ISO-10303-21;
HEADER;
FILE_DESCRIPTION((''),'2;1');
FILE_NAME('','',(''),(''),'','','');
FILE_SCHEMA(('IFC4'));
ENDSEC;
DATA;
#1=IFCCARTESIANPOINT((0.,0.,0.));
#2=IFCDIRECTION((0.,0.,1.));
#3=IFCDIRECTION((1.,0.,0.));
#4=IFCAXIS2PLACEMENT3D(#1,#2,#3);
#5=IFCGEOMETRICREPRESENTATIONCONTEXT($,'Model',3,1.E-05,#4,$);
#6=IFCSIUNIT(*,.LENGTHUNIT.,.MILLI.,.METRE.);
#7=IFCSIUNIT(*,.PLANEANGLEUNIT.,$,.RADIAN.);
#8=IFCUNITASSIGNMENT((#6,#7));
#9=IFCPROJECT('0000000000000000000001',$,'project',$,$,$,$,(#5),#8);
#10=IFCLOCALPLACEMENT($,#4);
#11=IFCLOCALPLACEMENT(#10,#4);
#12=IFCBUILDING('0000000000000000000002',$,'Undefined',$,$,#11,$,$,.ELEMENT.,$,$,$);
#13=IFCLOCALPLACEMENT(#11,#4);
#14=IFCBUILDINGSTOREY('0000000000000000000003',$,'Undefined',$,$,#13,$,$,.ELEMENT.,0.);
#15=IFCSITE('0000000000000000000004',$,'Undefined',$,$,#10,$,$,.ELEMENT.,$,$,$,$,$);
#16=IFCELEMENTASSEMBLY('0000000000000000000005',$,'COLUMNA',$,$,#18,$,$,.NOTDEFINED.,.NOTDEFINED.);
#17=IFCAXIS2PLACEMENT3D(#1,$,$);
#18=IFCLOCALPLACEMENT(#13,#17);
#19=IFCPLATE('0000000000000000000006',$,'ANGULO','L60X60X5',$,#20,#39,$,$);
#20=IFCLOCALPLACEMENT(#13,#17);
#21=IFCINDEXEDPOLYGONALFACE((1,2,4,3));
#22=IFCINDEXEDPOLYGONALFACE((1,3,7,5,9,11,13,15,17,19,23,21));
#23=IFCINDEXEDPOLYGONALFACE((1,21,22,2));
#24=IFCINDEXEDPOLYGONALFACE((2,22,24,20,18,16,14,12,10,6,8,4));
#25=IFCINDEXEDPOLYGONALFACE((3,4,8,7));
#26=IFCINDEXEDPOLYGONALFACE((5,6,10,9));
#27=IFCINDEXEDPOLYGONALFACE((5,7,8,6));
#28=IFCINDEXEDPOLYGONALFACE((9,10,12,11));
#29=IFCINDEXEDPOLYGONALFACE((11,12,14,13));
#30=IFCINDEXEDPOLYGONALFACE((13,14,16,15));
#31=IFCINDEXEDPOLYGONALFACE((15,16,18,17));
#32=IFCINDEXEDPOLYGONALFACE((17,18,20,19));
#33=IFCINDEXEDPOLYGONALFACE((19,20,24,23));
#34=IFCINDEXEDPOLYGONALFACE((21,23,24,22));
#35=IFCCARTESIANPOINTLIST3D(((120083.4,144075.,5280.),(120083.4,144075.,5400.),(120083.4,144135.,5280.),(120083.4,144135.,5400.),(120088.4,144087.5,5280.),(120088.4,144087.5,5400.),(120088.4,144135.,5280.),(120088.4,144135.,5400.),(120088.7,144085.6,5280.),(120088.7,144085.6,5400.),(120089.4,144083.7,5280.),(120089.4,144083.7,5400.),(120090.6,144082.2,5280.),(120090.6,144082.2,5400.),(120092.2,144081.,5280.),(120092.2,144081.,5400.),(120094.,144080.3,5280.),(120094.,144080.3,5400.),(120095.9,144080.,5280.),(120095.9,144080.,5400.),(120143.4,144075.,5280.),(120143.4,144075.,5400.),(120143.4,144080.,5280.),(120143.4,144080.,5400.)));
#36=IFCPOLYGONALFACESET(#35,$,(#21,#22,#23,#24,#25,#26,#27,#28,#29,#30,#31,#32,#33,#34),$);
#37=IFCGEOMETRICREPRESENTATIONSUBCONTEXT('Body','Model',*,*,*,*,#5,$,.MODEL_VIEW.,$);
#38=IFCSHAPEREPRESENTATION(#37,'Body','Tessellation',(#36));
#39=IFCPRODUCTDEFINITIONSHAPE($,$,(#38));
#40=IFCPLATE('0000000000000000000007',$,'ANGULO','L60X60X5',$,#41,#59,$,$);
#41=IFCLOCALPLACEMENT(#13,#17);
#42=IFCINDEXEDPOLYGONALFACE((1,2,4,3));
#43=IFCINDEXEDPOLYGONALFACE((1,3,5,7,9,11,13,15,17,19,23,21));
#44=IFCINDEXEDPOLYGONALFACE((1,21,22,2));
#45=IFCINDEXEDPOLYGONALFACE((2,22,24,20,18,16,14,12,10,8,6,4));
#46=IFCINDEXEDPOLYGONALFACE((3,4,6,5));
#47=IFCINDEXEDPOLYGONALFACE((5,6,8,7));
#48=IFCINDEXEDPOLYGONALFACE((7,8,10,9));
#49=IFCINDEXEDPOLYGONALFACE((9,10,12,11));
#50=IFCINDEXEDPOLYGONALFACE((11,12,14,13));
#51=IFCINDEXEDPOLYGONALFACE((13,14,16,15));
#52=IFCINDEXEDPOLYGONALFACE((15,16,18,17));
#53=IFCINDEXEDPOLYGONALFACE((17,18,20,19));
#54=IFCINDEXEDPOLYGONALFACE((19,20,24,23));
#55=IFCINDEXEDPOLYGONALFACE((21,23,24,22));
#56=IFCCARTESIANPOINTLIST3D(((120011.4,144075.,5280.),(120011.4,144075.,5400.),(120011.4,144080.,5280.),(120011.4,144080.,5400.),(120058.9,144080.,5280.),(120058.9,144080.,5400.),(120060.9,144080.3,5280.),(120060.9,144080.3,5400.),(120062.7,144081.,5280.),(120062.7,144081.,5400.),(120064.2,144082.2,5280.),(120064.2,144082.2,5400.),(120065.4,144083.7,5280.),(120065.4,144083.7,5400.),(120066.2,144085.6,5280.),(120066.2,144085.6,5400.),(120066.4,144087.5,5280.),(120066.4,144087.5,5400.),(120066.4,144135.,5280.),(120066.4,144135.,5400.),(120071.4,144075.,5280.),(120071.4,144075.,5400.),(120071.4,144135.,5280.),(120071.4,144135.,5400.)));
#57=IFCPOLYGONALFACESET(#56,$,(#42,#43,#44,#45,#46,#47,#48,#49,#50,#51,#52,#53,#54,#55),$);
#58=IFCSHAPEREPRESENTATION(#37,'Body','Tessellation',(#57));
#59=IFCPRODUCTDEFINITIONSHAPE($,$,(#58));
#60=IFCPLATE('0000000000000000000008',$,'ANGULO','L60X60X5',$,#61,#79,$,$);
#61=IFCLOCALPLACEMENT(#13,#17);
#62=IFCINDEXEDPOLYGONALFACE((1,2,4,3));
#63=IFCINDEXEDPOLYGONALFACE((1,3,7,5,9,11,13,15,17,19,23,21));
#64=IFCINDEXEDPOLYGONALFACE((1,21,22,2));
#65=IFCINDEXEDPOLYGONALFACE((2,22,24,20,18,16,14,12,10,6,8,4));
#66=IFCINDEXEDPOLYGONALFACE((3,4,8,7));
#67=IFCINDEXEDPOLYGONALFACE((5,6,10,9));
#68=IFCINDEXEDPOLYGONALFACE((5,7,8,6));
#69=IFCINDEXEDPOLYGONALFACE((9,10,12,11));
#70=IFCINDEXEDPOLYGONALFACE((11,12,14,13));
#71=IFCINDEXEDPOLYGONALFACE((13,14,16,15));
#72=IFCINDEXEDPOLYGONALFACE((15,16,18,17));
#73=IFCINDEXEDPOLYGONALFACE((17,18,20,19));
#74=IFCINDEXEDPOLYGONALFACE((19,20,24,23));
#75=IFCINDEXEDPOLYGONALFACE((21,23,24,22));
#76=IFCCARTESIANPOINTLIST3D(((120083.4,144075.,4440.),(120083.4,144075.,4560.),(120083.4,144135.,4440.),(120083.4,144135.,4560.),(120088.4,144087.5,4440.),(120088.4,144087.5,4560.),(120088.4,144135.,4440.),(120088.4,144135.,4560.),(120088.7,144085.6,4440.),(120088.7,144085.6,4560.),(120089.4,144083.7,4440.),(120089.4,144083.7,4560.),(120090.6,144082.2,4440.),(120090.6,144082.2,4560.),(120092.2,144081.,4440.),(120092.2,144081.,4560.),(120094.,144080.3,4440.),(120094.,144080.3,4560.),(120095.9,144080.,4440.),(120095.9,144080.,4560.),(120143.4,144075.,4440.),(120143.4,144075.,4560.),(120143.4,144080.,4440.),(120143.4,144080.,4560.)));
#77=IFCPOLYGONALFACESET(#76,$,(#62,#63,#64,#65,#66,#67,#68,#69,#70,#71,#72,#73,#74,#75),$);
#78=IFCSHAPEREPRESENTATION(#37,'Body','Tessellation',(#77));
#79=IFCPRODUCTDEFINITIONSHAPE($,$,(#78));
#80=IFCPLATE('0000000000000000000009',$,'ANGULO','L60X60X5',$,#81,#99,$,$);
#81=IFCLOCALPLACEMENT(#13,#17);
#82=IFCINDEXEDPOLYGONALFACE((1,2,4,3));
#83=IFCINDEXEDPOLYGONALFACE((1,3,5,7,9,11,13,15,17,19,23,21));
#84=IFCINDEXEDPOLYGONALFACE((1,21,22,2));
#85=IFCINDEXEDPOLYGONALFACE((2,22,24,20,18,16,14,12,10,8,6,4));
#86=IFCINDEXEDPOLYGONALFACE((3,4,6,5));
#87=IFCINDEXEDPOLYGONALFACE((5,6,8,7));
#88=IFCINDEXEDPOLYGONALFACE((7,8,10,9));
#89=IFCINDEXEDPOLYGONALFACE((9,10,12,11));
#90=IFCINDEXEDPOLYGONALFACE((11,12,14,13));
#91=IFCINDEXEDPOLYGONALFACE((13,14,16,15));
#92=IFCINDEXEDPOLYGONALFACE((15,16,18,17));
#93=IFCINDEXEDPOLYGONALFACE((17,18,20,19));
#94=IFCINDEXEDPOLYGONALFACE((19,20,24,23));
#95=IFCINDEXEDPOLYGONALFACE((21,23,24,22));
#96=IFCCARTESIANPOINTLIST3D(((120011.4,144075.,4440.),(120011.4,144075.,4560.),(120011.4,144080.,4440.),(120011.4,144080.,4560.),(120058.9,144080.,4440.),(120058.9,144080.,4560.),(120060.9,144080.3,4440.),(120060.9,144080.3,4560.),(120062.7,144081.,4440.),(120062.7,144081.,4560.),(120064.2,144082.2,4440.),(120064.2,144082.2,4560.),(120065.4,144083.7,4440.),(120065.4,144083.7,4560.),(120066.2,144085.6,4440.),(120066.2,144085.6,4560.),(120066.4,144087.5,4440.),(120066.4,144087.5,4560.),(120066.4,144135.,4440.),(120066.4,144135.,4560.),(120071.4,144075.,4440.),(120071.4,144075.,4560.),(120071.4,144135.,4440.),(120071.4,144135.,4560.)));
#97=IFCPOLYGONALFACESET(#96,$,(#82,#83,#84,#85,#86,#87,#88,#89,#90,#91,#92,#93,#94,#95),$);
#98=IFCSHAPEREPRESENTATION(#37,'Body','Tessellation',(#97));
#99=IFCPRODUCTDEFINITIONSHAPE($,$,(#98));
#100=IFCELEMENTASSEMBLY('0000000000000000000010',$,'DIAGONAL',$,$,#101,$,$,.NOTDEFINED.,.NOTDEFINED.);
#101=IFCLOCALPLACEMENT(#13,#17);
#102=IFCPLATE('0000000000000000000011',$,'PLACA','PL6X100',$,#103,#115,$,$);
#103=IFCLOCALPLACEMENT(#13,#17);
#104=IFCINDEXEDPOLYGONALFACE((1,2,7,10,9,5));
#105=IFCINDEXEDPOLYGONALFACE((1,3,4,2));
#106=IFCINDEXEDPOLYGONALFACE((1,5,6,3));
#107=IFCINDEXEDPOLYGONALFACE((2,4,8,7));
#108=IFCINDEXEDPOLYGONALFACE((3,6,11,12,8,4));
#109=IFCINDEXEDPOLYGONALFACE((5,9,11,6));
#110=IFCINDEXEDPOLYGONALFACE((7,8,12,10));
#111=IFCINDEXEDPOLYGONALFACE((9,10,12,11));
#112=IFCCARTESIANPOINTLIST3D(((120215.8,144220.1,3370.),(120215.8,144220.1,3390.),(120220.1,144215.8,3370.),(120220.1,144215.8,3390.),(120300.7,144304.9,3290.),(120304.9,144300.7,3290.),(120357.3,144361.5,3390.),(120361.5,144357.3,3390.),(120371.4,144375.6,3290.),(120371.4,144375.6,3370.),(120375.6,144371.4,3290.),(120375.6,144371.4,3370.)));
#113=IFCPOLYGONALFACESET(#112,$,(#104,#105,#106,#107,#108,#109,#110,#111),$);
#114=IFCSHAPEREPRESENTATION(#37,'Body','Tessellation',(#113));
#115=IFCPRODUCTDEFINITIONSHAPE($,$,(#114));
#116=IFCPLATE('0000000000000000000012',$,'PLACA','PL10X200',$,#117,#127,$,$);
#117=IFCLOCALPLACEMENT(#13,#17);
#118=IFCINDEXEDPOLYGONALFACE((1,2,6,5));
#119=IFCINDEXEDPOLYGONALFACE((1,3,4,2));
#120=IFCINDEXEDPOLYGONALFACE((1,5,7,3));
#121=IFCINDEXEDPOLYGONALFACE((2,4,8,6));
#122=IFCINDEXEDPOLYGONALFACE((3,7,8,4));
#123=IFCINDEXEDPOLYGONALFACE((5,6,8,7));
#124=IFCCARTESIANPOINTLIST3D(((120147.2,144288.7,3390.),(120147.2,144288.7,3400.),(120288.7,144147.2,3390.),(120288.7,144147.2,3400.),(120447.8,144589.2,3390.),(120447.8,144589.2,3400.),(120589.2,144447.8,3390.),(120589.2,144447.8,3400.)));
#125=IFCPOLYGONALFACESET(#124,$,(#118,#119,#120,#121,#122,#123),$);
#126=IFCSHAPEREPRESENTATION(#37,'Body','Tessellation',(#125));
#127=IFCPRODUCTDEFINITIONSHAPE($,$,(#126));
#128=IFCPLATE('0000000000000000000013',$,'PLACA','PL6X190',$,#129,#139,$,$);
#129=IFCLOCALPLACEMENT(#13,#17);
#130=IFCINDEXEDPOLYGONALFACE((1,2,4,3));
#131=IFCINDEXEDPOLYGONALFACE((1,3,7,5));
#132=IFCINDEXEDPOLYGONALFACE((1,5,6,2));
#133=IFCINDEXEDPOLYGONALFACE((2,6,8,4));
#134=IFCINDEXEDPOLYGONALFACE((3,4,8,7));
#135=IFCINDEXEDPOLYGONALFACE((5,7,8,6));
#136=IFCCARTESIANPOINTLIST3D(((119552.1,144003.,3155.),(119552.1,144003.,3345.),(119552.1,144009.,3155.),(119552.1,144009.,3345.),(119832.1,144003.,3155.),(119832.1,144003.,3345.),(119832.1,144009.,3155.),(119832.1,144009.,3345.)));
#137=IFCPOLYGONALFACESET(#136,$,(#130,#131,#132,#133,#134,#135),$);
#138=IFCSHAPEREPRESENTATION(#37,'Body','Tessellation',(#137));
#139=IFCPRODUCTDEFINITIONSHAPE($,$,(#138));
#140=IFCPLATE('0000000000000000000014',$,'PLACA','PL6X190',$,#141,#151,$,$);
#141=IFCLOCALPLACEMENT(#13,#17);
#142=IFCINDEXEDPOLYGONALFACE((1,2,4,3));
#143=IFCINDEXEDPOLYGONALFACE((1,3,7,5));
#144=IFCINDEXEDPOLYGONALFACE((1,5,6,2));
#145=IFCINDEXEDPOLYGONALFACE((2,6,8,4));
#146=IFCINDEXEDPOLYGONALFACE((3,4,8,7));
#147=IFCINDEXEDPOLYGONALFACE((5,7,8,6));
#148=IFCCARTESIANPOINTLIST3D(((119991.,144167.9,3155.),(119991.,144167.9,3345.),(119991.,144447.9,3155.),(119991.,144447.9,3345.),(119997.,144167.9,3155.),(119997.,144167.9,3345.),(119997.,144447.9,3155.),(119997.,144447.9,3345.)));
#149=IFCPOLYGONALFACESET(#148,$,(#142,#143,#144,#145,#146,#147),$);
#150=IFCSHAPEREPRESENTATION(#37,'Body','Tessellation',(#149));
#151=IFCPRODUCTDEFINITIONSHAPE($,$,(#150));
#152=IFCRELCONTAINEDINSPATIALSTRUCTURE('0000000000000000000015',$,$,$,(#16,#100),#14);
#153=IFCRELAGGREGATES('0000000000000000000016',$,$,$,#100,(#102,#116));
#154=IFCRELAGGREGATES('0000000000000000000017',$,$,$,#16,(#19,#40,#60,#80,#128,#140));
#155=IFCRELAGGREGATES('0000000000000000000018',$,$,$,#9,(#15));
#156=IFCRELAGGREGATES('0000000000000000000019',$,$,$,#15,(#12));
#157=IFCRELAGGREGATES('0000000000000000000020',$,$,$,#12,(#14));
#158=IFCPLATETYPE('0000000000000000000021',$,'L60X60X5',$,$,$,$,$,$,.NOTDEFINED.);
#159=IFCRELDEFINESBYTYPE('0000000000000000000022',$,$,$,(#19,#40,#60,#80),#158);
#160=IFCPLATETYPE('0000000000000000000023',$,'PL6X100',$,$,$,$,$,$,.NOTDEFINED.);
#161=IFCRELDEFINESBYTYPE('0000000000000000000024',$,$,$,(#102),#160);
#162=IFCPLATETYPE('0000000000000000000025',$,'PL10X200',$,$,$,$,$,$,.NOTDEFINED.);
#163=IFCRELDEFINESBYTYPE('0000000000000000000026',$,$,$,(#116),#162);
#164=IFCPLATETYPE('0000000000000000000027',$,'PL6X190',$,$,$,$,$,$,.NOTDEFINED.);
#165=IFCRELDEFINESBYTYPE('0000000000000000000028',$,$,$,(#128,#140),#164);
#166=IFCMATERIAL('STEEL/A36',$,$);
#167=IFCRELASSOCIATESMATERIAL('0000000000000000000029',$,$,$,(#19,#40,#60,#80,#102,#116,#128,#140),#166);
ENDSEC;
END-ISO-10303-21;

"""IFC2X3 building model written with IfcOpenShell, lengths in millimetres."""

from ifc_helpers import new_model, si_unit, frame, origin_with_axes, origin_2d_with_axis, place, context, subcontext, project, spatial, polyline, l_section, outline, extrude, material, type_object, element, aggregate, save


model = new_model("IFC2X3")

# Units and contexts
model_context = context("Model", 3, precision=1e-05, world=origin_with_axes())
body_context = subcontext(model_context, "Body", "Model", "MODEL_VIEW")
ifc_project = project(units=[si_unit("LENGTHUNIT", "METRE", prefix="MILLI"), si_unit("PLANEANGLEUNIT", "RADIAN")], contexts=[model_context])

# Site, building, storey
site_placement = place(None, origin_with_axes())
site = spatial("IfcSite", under=ifc_project, at=site_placement, Name="Undefined", CompositionType="ELEMENT")
building_placement = place(site_placement, origin_with_axes())
building = spatial("IfcBuilding", under=site, at=building_placement, Name="Undefined", CompositionType="ELEMENT")
storey_placement = place(building_placement, origin_with_axes())
storey = spatial("IfcBuildingStorey", under=building, at=storey_placement, Name="Undefined", CompositionType="ELEMENT", Elevation=0.0)

# Element assembly
assembly_1_placement = place(storey_placement, origin_with_axes())
assembly_1 = element("IfcElementAssembly", 1, at=assembly_1_placement, inside=storey, Name="COLUMNA", AssemblyPlace="NOTDEFINED", PredefinedType="NOTDEFINED")
ifc_material_1 = material(Name="STEEL/A36")

# Plates
plate_type_1 = type_object("IfcPlateType", Name="L60X60X5", PredefinedType="NOTDEFINED")
plate_1_placement = place(assembly_1_placement, frame((120113.4, 144105.0, 5280.0), z_axis=(1.0, 0.0, 0.0), x_axis=(0.0, 0.0, 1.0)))
plate_1 = element("IfcPlate", 2, at=plate_1_placement, type_object=plate_type_1, material=ifc_material_1, Name="ANGULO", Description="L60X60X5", context=body_context, shape_type="SweptSolid", body=[
    extrude(l_section(Depth=60.0, Width=60.0, Thickness=5.0, FilletRadius=7.5, at=origin_2d_with_axis()), frame((120.0, 0.0, 0.0), z_axis=(-1.0, 0.0, 0.0), x_axis=(0.0, -1.0, 0.0)), (0.0, 0.0, 1.0), 120.0),
])
plate_2_placement = place(assembly_1_placement, frame((120041.4, 144105.0, 5400.0), z_axis=(-1.0, 0.0, 0.0), x_axis=(0.0, 0.0, -1.0)))
plate_2 = element("IfcPlate", 3, at=plate_2_placement, type_object=plate_type_1, material=ifc_material_1, Name="ANGULO", Description="L60X60X5", context=body_context, shape_type="SweptSolid", body=[
    extrude(l_section(Depth=60.0, Width=60.0, Thickness=5.0, FilletRadius=7.5, at=origin_2d_with_axis()), frame((120.0, 0.0, 0.0), z_axis=(-1.0, 0.0, 0.0), x_axis=(0.0, -1.0, 0.0)), (0.0, 0.0, 1.0), 120.0),
])
plate_3_placement = place(assembly_1_placement, frame((120113.4, 144105.0, 4440.0), z_axis=(1.0, 0.0, 0.0), x_axis=(0.0, 0.0, 1.0)))
plate_3 = element("IfcPlate", 4, at=plate_3_placement, type_object=plate_type_1, material=ifc_material_1, Name="ANGULO", Description="L60X60X5", context=body_context, shape_type="SweptSolid", body=[
    extrude(l_section(Depth=60.0, Width=60.0, Thickness=5.0, FilletRadius=7.5, at=origin_2d_with_axis()), frame((120.0, 0.0, 0.0), z_axis=(-1.0, 0.0, 0.0), x_axis=(0.0, -1.0, 0.0)), (0.0, 0.0, 1.0), 120.0),
])
plate_4_placement = place(assembly_1_placement, frame((120041.4, 144105.0, 4560.0), z_axis=(-1.0, 0.0, 0.0), x_axis=(0.0, 0.0, -1.0)))
plate_4 = element("IfcPlate", 5, at=plate_4_placement, type_object=plate_type_1, material=ifc_material_1, Name="ANGULO", Description="L60X60X5", context=body_context, shape_type="SweptSolid", body=[
    extrude(l_section(Depth=60.0, Width=60.0, Thickness=5.0, FilletRadius=7.5, at=origin_2d_with_axis()), frame((120.0, 0.0, 0.0), z_axis=(-1.0, 0.0, 0.0), x_axis=(0.0, -1.0, 0.0)), (0.0, 0.0, 1.0), 120.0),
])

# Element assembly, plates
assembly_2_placement = place(storey_placement, origin_with_axes())
assembly_2 = element("IfcElementAssembly", 6, at=assembly_2_placement, inside=storey, Name="DIAGONAL", AssemblyPlace="NOTDEFINED", PredefinedType="NOTDEFINED")
plate_type_2 = type_object("IfcPlateType", Name="PL6X100", PredefinedType="NOTDEFINED")
plate_5_placement = place(assembly_2_placement, frame((120218.0, 144218.0, 3290.0), z_axis=(0.707107, -0.707107, 0.0), x_axis=(0.707107, 0.707107, 0.0)))
plate_5 = element("IfcPlate", 7, at=plate_5_placement, type_object=plate_type_2, material=ifc_material_1, Name="PLACA", Description="PL6X100", context=body_context, shape_type="SweptSolid", body=[
    extrude(outline(polyline([(0.0, 80.0), (120.0, 0.0), (220.0, 0.0), (220.0, 80.0), (200.0, 100.0), (0.0, 100.0), (0.0, 80.0)])), frame((0.0, 0.0, -3.0), z_axis=(0.0, 0.0, 1.0), x_axis=(1.0, 0.0, 0.0)), (0.0, 0.0, 1.0), 6.0),
])
plate_type_3 = type_object("IfcPlateType", Name="PL10X200", PredefinedType="NOTDEFINED")
plate_6_placement = place(assembly_2_placement, frame((120218.0, 144218.0, 3395.0), z_axis=(0.0, 0.0, -1.0), x_axis=(0.707107, 0.707107, 0.0)))
plate_6 = element("IfcPlate", 8, at=plate_6_placement, type_object=plate_type_3, material=ifc_material_1, Name="PLACA", Description="PL10X200", context=body_context, shape_type="SweptSolid", body=[
    extrude(outline(polyline([(0.0, -100.0), (0.0, 100.0), (425.0, 100.0), (425.0, -100.0), (0.0, -100.0)])), frame((0.0, 0.0, -5.0), z_axis=(0.0, 0.0, 1.0), x_axis=(1.0, 0.0, 0.0)), (0.0, 0.0, 1.0), 10.0),
])
aggregate(assembly_2, [plate_5, plate_6])

# Plates
plate_type_4 = type_object("IfcPlateType", Name="PL6X190", PredefinedType="NOTDEFINED")
plate_7_placement = place(assembly_1_placement, frame((119552.1, 144006.0, 3250.0), z_axis=(0.0, -1.0, 0.0), x_axis=(1.0, 0.0, 0.0)))
plate_7 = element("IfcPlate", 9, at=plate_7_placement, type_object=plate_type_4, material=ifc_material_1, Name="PLACA", Description="PL6X190", context=body_context, shape_type="SweptSolid", body=[
    extrude(outline(polyline([(0.0, -95.0), (0.0, 95.0), (280.0, 95.0), (280.0, -95.0), (0.0, -95.0)])), frame((0.0, 0.0, -3.0), z_axis=(0.0, 0.0, 1.0), x_axis=(1.0, 0.0, 0.0)), (0.0, 0.0, 1.0), 6.0),
])
plate_8_placement = place(assembly_1_placement, frame((119994.0, 144447.9, 3250.0), z_axis=(-1.0, 0.0, 0.0), x_axis=(0.0, -1.0, 0.0)))
plate_8 = element("IfcPlate", 10, at=plate_8_placement, type_object=plate_type_4, material=ifc_material_1, Name="PLACA", Description="PL6X190", context=body_context, shape_type="SweptSolid", body=[
    extrude(outline(polyline([(0.0, -95.0), (0.0, 95.0), (280.0, 95.0), (280.0, -95.0), (0.0, -95.0)])), frame((0.0, 0.0, -3.0), z_axis=(0.0, 0.0, 1.0), x_axis=(1.0, 0.0, 0.0)), (0.0, 0.0, 1.0), 6.0),
])

aggregate(assembly_1, [plate_1, plate_2, plate_3, plate_4, plate_7, plate_8])

save(model, "model.ifc")
